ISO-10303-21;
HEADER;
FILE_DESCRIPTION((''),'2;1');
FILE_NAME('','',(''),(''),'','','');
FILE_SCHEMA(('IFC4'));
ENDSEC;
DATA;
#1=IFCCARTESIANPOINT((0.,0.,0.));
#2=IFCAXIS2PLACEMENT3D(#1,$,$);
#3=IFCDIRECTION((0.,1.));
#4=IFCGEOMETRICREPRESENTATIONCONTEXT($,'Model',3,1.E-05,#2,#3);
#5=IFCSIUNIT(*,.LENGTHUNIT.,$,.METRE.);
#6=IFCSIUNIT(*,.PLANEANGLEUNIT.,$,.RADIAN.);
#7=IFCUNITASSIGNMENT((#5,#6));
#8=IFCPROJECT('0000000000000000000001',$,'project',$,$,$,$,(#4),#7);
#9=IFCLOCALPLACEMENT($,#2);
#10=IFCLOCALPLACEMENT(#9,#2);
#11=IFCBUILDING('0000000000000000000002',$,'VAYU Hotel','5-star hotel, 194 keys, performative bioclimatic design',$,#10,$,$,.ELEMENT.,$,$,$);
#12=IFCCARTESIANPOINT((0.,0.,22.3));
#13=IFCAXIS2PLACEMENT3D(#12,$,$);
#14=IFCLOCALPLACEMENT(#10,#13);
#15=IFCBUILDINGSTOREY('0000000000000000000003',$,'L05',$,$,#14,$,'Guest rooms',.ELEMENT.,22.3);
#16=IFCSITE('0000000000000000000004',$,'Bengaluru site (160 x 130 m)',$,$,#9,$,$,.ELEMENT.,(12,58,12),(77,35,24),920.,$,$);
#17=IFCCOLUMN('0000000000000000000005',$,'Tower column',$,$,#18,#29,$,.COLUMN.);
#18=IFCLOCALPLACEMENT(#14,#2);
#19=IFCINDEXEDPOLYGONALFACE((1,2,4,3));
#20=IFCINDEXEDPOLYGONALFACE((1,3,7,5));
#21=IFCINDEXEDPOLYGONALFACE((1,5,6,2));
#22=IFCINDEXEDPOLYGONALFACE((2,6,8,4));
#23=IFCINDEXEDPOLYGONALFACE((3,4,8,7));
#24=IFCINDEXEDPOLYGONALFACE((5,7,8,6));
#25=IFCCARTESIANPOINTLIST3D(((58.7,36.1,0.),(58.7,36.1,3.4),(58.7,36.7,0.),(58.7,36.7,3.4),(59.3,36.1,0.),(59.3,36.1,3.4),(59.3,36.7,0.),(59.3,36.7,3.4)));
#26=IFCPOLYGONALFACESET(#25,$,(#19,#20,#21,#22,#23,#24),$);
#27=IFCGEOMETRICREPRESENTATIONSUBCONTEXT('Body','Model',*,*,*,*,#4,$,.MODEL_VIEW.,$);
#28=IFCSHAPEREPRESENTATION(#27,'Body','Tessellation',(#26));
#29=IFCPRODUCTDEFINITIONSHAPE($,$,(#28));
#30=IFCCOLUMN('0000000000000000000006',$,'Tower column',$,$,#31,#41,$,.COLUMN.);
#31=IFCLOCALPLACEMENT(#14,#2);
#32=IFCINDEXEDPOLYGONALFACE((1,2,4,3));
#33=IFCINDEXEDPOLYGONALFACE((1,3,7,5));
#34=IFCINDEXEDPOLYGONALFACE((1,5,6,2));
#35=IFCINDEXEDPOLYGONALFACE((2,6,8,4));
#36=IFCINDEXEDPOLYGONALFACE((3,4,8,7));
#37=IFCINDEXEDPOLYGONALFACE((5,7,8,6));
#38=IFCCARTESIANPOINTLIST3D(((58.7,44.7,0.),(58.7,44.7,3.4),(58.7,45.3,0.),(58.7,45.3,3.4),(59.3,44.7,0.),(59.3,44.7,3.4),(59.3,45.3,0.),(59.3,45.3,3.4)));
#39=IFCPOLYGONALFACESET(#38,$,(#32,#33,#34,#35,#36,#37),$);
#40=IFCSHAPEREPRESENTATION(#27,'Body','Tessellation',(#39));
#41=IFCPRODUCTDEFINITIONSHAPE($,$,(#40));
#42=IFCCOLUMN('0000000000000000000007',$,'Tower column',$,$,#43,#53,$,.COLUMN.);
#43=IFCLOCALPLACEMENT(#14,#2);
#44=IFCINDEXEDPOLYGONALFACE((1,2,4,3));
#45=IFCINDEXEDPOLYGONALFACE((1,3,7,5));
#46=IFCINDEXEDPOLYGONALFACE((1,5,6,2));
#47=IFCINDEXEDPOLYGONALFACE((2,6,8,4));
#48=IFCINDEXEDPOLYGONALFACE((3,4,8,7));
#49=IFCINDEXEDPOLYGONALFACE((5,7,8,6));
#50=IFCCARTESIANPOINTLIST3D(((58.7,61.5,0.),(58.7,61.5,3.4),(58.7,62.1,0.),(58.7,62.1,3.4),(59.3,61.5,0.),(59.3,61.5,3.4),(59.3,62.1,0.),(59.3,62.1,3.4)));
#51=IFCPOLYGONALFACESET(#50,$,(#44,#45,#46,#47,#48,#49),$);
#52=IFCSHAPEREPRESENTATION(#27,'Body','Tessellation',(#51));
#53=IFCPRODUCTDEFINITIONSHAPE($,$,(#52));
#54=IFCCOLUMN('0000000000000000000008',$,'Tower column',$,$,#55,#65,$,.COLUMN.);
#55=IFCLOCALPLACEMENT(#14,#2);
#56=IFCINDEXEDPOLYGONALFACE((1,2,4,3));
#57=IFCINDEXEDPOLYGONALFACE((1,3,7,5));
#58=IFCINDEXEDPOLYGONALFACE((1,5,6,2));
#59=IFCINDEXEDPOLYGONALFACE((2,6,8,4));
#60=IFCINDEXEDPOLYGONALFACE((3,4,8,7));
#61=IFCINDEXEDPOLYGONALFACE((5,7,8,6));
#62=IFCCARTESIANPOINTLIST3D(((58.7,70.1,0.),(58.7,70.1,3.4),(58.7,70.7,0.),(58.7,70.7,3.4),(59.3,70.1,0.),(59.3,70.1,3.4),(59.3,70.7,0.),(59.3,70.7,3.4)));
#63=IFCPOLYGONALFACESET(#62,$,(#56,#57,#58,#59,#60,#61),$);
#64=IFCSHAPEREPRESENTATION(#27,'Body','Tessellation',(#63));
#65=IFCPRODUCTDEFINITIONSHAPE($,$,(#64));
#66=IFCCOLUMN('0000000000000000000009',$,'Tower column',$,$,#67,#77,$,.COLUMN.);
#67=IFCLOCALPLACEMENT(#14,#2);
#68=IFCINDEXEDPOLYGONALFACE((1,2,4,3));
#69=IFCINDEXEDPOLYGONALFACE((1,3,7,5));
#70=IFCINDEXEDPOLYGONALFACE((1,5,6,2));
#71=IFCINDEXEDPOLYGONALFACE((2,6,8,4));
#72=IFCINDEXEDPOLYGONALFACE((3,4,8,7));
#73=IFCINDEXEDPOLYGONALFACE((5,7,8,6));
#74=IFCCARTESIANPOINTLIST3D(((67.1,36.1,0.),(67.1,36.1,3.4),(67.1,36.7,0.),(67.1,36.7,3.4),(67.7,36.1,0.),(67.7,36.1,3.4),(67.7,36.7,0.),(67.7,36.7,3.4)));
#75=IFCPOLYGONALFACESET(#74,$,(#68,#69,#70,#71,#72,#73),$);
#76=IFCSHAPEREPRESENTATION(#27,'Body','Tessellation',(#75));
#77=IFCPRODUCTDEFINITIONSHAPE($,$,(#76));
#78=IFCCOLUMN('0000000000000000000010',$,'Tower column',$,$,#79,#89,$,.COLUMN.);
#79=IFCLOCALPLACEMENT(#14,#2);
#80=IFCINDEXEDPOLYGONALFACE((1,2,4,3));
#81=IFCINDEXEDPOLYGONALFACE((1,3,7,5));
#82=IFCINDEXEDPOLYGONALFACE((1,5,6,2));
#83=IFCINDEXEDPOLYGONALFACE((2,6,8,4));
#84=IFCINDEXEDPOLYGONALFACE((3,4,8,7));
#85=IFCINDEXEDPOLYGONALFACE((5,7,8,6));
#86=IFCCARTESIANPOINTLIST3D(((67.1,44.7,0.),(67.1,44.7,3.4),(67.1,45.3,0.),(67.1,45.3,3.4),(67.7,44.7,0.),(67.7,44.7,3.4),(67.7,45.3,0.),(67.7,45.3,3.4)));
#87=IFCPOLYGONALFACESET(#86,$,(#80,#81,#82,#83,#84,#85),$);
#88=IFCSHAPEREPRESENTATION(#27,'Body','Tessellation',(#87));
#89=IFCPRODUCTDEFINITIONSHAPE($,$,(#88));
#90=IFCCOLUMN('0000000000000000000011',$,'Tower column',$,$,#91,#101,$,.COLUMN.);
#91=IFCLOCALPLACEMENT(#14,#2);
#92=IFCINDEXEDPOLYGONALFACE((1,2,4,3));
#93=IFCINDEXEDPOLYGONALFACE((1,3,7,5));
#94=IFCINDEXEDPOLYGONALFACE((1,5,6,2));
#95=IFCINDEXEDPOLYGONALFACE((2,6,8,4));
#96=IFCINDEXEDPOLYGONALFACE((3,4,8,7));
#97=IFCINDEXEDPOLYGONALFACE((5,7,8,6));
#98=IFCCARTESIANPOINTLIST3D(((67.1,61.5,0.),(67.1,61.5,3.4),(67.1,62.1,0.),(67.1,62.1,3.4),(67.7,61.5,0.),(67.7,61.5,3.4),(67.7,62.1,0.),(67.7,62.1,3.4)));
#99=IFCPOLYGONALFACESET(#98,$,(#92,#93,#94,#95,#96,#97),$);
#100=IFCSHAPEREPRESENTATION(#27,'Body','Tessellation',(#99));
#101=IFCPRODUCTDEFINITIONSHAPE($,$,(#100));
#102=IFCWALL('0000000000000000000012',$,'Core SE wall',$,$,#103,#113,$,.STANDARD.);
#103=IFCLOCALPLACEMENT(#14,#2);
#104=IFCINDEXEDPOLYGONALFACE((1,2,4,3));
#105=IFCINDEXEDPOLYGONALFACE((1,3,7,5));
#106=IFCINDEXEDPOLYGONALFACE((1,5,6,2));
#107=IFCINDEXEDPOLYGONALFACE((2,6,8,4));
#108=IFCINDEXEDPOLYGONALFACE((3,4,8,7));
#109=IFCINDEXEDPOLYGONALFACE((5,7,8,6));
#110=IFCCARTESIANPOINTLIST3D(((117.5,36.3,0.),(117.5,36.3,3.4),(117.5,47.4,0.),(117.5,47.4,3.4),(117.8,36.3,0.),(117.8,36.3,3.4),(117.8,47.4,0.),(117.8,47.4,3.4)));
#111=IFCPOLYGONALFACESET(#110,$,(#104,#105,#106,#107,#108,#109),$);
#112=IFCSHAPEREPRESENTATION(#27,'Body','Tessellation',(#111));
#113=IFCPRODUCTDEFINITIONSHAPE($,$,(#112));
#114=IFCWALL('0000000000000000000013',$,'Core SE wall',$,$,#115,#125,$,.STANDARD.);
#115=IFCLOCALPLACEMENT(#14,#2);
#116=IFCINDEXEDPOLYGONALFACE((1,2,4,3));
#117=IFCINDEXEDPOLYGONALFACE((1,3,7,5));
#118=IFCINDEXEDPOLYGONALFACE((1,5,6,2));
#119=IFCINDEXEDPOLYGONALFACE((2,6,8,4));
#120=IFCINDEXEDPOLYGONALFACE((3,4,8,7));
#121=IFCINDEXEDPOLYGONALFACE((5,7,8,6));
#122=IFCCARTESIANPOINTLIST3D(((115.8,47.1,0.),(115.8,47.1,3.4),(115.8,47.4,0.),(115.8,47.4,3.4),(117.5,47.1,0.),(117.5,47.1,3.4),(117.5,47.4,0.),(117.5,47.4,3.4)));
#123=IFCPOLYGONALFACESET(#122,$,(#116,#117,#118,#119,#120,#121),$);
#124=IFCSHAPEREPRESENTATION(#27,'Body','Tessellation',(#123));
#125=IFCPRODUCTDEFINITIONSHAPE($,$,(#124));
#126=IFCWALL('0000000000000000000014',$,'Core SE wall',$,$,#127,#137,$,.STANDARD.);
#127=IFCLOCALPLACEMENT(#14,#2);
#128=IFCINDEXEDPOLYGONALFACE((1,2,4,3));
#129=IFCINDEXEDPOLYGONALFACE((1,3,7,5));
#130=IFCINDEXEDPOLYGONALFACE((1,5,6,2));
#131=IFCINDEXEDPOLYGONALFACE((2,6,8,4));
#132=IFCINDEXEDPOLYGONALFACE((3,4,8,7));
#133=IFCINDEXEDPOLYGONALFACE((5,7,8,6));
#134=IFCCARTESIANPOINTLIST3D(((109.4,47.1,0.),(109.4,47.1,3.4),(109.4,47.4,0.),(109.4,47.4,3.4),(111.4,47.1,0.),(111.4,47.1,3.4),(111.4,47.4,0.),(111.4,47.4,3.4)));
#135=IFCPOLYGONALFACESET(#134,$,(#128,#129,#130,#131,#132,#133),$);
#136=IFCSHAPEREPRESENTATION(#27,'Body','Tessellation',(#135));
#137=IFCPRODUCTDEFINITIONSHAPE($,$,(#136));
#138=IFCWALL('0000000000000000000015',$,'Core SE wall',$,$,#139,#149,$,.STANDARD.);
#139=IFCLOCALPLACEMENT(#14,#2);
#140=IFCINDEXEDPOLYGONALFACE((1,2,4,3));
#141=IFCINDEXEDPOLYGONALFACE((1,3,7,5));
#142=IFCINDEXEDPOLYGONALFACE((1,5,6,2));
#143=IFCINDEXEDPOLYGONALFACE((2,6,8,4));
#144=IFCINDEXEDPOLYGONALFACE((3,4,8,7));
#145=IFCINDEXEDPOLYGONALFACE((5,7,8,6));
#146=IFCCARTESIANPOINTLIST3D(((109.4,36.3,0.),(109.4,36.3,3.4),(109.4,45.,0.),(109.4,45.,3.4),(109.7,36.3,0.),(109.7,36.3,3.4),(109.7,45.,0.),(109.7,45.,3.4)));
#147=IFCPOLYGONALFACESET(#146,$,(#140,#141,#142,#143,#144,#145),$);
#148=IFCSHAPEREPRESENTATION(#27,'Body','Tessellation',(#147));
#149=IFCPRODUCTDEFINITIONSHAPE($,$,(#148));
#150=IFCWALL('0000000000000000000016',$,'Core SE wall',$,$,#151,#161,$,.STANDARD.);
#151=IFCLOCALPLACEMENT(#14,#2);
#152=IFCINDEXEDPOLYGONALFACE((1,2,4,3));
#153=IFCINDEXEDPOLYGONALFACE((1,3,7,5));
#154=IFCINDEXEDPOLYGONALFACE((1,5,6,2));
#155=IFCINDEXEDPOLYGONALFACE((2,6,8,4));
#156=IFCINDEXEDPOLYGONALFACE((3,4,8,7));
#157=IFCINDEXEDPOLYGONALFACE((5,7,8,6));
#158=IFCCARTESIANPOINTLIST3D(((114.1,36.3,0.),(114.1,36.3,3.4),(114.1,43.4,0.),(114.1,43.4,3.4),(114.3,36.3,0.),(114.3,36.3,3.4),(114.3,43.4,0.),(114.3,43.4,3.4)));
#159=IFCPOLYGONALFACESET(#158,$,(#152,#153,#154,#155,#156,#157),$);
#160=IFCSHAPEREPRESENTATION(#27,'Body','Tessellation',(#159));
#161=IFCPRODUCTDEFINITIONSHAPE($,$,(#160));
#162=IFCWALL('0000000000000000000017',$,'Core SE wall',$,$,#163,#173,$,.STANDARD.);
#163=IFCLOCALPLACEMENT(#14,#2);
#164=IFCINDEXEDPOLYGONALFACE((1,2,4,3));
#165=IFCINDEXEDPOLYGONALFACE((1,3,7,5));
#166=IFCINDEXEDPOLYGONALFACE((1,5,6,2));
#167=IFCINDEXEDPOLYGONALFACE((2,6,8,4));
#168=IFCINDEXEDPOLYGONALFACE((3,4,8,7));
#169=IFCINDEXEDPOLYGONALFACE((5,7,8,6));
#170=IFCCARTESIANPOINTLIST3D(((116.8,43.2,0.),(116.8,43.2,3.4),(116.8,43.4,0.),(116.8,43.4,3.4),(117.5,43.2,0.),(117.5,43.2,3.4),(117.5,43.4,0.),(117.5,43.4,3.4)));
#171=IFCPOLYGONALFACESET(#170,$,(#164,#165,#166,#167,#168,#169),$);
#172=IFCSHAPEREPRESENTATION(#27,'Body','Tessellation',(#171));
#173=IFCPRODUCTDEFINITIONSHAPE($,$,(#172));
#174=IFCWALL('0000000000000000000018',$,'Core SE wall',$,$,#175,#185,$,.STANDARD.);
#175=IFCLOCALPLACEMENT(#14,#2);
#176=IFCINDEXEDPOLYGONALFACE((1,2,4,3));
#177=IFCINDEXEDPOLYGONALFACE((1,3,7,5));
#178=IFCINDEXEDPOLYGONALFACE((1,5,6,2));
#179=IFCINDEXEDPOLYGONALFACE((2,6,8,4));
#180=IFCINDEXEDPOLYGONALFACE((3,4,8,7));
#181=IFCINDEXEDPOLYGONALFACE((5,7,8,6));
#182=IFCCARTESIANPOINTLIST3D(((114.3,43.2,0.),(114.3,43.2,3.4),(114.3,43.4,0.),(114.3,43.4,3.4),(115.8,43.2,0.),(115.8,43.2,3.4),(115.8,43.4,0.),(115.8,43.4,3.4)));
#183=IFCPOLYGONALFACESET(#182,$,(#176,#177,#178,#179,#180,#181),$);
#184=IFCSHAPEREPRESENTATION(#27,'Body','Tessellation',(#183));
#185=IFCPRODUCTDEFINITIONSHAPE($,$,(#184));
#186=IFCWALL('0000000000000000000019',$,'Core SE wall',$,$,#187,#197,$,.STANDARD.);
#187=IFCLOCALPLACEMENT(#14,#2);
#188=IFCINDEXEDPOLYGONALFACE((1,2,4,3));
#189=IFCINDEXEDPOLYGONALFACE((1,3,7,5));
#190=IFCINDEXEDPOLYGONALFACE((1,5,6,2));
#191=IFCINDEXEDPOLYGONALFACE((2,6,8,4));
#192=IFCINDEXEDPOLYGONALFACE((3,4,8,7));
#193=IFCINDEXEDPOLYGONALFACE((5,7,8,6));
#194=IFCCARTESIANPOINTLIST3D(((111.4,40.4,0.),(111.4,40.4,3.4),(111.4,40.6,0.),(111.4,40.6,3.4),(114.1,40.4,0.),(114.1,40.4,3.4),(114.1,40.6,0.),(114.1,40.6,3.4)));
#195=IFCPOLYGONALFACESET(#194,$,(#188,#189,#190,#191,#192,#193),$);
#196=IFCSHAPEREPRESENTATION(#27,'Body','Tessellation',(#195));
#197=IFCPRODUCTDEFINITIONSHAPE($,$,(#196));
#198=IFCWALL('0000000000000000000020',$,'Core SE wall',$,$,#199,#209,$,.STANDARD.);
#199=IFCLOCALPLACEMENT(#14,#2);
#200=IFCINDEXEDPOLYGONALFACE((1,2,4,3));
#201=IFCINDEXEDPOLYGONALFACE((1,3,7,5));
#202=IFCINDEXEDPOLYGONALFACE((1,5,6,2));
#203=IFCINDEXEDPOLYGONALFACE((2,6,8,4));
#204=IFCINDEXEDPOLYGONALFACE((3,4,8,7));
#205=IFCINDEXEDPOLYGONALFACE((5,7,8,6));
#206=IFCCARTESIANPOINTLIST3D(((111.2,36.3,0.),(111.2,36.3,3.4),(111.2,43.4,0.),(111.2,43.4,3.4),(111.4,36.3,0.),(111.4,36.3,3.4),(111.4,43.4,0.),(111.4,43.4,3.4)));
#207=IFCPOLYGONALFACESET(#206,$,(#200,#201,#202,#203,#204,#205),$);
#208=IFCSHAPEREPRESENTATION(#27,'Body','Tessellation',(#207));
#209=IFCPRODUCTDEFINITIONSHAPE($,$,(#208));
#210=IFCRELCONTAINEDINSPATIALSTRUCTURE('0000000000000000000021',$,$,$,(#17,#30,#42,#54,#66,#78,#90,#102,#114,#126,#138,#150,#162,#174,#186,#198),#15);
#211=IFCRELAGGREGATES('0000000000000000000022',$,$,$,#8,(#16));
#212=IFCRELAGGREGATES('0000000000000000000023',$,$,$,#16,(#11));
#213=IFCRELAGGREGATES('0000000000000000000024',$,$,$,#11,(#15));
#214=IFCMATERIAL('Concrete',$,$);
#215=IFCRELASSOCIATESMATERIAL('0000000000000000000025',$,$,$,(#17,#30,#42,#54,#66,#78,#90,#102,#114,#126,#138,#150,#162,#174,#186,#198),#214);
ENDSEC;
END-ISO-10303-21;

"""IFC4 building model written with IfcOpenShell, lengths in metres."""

from ifc_helpers import new_model, si_unit, direction, frame, origin, place, context, subcontext, project, spatial, polyline, outline, extrude, material, element, save


model = new_model("IFC4")

# Units and contexts
model_context = context("Model", 3, precision=1e-05, world=origin(), true_north=direction((0.0, 1.0)))
body_context = subcontext(model_context, "Body", "Model", "MODEL_VIEW")
ifc_project = project(units=[si_unit("LENGTHUNIT", "METRE"), si_unit("PLANEANGLEUNIT", "RADIAN")], contexts=[model_context])

# Site, building, storey
site_placement = place(None, origin())
site = spatial("IfcSite", under=ifc_project, at=site_placement, Name="Bengaluru site (160 x 130 m)", CompositionType="ELEMENT", RefLatitude=(12, 58, 12), RefLongitude=(77, 35, 24), RefElevation=920.0)
building_placement = place(site_placement, origin())
building = spatial("IfcBuilding", under=site, at=building_placement, Name="VAYU Hotel", Description="5-star hotel, 194 keys, performative bioclimatic design", CompositionType="ELEMENT")
storey_placement = place(building_placement, frame((0.0, 0.0, 22.3)))
storey = spatial("IfcBuildingStorey", under=building, at=storey_placement, Name="L05", LongName="Guest rooms", CompositionType="ELEMENT", Elevation=22.3)

# Columns
ifc_material_1 = material(Name="Concrete")
column_1_placement = place(storey_placement, origin())
element("IfcColumn", 1, at=column_1_placement, inside=storey, material=ifc_material_1, Name="Tower column", PredefinedType="COLUMN", context=body_context, shape_type="SweptSolid", body=[
    extrude(outline(polyline([(58.7, 36.1), (59.3, 36.1), (59.3, 36.7), (58.7, 36.7), (58.7, 36.1)])), origin(), (0.0, 0.0, 1.0), 3.4),
])
column_2_placement = place(storey_placement, origin())
element("IfcColumn", 2, at=column_2_placement, inside=storey, material=ifc_material_1, Name="Tower column", PredefinedType="COLUMN", context=body_context, shape_type="SweptSolid", body=[
    extrude(outline(polyline([(58.7, 44.7), (59.3, 44.7), (59.3, 45.3), (58.7, 45.3), (58.7, 44.7)])), origin(), (0.0, 0.0, 1.0), 3.4),
])
column_3_placement = place(storey_placement, origin())
element("IfcColumn", 3, at=column_3_placement, inside=storey, material=ifc_material_1, Name="Tower column", PredefinedType="COLUMN", context=body_context, shape_type="SweptSolid", body=[
    extrude(outline(polyline([(58.7, 61.5), (59.3, 61.5), (59.3, 62.1), (58.7, 62.1), (58.7, 61.5)])), origin(), (0.0, 0.0, 1.0), 3.4),
])
column_4_placement = place(storey_placement, origin())
element("IfcColumn", 4, at=column_4_placement, inside=storey, material=ifc_material_1, Name="Tower column", PredefinedType="COLUMN", context=body_context, shape_type="SweptSolid", body=[
    extrude(outline(polyline([(58.7, 70.1), (59.3, 70.1), (59.3, 70.7), (58.7, 70.7), (58.7, 70.1)])), origin(), (0.0, 0.0, 1.0), 3.4),
])
column_5_placement = place(storey_placement, origin())
element("IfcColumn", 5, at=column_5_placement, inside=storey, material=ifc_material_1, Name="Tower column", PredefinedType="COLUMN", context=body_context, shape_type="SweptSolid", body=[
    extrude(outline(polyline([(67.1, 36.1), (67.7, 36.1), (67.7, 36.7), (67.1, 36.7), (67.1, 36.1)])), origin(), (0.0, 0.0, 1.0), 3.4),
])
column_6_placement = place(storey_placement, origin())
element("IfcColumn", 6, at=column_6_placement, inside=storey, material=ifc_material_1, Name="Tower column", PredefinedType="COLUMN", context=body_context, shape_type="SweptSolid", body=[
    extrude(outline(polyline([(67.1, 44.7), (67.7, 44.7), (67.7, 45.3), (67.1, 45.3), (67.1, 44.7)])), origin(), (0.0, 0.0, 1.0), 3.4),
])
column_7_placement = place(storey_placement, origin())
element("IfcColumn", 7, at=column_7_placement, inside=storey, material=ifc_material_1, Name="Tower column", PredefinedType="COLUMN", context=body_context, shape_type="SweptSolid", body=[
    extrude(outline(polyline([(67.1, 61.5), (67.7, 61.5), (67.7, 62.1), (67.1, 62.1), (67.1, 61.5)])), origin(), (0.0, 0.0, 1.0), 3.4),
])

# Walls
wall_1_placement = place(storey_placement, origin())
element("IfcWall", 8, at=wall_1_placement, inside=storey, material=ifc_material_1, Name="Core SE wall", PredefinedType="STANDARD", context=body_context, shape_type="SweptSolid", body=[
    extrude(outline(polyline([(117.5, 36.3), (117.5, 47.4), (117.8, 47.4), (117.8, 36.3), (117.5, 36.3)])), origin(), (0.0, 0.0, 1.0), 3.4),
])
wall_2_placement = place(storey_placement, origin())
element("IfcWall", 9, at=wall_2_placement, inside=storey, material=ifc_material_1, Name="Core SE wall", PredefinedType="STANDARD", context=body_context, shape_type="SweptSolid", body=[
    extrude(outline(polyline([(115.8, 47.4), (117.5, 47.4), (117.5, 47.1), (115.8, 47.1), (115.8, 47.4)])), origin(), (0.0, 0.0, 1.0), 3.4),
])
wall_3_placement = place(storey_placement, origin())
element("IfcWall", 10, at=wall_3_placement, inside=storey, material=ifc_material_1, Name="Core SE wall", PredefinedType="STANDARD", context=body_context, shape_type="SweptSolid", body=[
    extrude(outline(polyline([(109.4, 47.4), (111.4, 47.4), (111.4, 47.1), (109.4, 47.1), (109.4, 47.4)])), origin(), (0.0, 0.0, 1.0), 3.4),
])
wall_4_placement = place(storey_placement, origin())
element("IfcWall", 11, at=wall_4_placement, inside=storey, material=ifc_material_1, Name="Core SE wall", PredefinedType="STANDARD", context=body_context, shape_type="SweptSolid", body=[
    extrude(outline(polyline([(109.4, 36.3), (109.4, 45.0), (109.7, 45.0), (109.7, 36.3), (109.4, 36.3)])), origin(), (0.0, 0.0, 1.0), 3.4),
])
wall_5_placement = place(storey_placement, origin())
element("IfcWall", 12, at=wall_5_placement, inside=storey, material=ifc_material_1, Name="Core SE wall", PredefinedType="STANDARD", context=body_context, shape_type="SweptSolid", body=[
    extrude(outline(polyline([(114.1, 36.3), (114.1, 43.4), (114.3, 43.4), (114.3, 36.3), (114.1, 36.3)])), origin(), (0.0, 0.0, 1.0), 3.4),
])
wall_6_placement = place(storey_placement, origin())
element("IfcWall", 13, at=wall_6_placement, inside=storey, material=ifc_material_1, Name="Core SE wall", PredefinedType="STANDARD", context=body_context, shape_type="SweptSolid", body=[
    extrude(outline(polyline([(116.8, 43.4), (117.5, 43.4), (117.5, 43.2), (116.8, 43.2), (116.8, 43.4)])), origin(), (0.0, 0.0, 1.0), 3.4),
])
wall_7_placement = place(storey_placement, origin())
element("IfcWall", 14, at=wall_7_placement, inside=storey, material=ifc_material_1, Name="Core SE wall", PredefinedType="STANDARD", context=body_context, shape_type="SweptSolid", body=[
    extrude(outline(polyline([(114.3, 43.4), (115.8, 43.4), (115.8, 43.2), (114.3, 43.2), (114.3, 43.4)])), origin(), (0.0, 0.0, 1.0), 3.4),
])
wall_8_placement = place(storey_placement, origin())
element("IfcWall", 15, at=wall_8_placement, inside=storey, material=ifc_material_1, Name="Core SE wall", PredefinedType="STANDARD", context=body_context, shape_type="SweptSolid", body=[
    extrude(outline(polyline([(111.4, 40.6), (114.1, 40.6), (114.1, 40.4), (111.4, 40.4), (111.4, 40.6)])), origin(), (0.0, 0.0, 1.0), 3.4),
])
wall_9_placement = place(storey_placement, origin())
element("IfcWall", 16, at=wall_9_placement, inside=storey, material=ifc_material_1, Name="Core SE wall", PredefinedType="STANDARD", context=body_context, shape_type="SweptSolid", body=[
    extrude(outline(polyline([(111.2, 36.3), (111.2, 43.4), (111.4, 43.4), (111.4, 36.3), (111.2, 36.3)])), origin(), (0.0, 0.0, 1.0), 3.4),
])

save(model, "model.ifc")
